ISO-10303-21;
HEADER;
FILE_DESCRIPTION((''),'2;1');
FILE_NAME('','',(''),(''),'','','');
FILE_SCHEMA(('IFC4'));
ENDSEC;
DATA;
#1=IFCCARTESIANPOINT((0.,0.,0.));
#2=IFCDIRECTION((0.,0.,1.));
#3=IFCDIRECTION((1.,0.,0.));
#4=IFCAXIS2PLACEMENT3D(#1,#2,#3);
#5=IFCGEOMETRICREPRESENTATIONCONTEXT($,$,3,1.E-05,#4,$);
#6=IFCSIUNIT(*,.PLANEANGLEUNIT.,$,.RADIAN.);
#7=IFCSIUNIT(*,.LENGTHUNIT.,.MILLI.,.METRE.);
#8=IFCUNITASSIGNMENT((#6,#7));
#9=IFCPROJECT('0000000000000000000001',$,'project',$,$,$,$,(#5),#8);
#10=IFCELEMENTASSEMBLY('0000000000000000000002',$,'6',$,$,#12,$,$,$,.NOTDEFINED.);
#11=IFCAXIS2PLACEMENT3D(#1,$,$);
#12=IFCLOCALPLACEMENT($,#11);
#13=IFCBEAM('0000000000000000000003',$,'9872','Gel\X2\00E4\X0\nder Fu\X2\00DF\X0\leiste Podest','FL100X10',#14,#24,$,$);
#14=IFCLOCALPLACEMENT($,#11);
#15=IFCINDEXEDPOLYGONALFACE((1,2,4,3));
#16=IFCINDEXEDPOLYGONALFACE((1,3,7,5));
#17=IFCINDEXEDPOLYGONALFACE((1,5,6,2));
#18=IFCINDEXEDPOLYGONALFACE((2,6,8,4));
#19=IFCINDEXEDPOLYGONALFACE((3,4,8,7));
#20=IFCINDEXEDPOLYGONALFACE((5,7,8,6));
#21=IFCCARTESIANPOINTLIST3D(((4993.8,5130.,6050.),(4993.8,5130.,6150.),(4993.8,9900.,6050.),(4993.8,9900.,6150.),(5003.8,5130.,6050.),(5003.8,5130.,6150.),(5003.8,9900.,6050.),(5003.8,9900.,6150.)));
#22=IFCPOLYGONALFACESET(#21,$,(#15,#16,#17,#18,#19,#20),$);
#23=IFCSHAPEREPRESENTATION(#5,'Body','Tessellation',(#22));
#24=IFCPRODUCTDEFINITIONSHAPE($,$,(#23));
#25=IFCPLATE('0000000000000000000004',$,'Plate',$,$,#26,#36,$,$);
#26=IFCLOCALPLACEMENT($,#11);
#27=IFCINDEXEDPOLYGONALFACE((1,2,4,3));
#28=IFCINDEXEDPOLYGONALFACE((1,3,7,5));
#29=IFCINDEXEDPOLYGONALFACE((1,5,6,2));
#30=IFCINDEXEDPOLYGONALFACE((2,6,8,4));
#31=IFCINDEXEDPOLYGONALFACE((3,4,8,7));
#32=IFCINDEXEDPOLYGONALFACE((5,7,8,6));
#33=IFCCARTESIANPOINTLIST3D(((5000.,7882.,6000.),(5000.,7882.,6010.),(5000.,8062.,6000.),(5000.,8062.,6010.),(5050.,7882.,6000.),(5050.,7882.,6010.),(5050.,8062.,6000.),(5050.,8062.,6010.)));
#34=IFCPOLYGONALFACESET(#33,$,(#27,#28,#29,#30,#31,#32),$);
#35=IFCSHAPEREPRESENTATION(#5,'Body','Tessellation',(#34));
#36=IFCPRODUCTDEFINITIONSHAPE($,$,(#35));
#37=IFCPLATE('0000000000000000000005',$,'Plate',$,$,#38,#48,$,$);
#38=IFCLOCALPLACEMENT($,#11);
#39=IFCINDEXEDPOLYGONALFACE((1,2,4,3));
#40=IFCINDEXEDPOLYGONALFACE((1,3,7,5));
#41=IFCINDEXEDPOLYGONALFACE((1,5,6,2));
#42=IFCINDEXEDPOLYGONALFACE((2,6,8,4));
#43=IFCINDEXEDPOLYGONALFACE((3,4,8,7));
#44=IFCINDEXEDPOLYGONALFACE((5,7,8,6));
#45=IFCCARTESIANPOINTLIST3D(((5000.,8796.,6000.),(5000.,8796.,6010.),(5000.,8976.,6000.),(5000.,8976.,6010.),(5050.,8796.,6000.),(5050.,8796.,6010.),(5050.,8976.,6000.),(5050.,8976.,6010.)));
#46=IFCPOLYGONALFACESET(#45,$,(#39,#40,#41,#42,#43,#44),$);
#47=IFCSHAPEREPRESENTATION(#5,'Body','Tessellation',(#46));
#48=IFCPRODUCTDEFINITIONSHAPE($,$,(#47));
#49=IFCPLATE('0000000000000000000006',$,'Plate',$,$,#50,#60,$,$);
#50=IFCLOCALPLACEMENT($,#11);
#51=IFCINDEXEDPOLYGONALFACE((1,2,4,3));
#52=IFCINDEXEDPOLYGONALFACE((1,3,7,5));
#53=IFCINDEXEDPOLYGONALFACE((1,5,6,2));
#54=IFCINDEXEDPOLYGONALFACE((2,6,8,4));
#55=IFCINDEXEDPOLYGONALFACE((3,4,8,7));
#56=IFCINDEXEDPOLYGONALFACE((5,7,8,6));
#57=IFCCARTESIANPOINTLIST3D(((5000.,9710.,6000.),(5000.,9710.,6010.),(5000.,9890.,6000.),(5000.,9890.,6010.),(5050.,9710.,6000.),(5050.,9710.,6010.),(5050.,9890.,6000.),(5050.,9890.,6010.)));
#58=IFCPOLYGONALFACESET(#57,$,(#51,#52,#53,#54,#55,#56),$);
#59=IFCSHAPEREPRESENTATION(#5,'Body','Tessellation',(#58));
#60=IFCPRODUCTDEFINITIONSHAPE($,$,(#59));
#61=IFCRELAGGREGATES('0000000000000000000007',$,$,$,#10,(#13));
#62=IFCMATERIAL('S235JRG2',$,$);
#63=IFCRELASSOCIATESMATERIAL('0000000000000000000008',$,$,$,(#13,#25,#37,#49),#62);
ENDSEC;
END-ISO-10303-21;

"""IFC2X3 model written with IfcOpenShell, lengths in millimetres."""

from ifc_helpers import new_model, si_unit, frame, origin_with_axes, place, context, project, polyline, outline, extrude, material, element, aggregate, save


model = new_model("IFC2X3")

# Units and contexts
context_of_model = context(None, 3, precision=1e-05, world=origin_with_axes())
ifc_project = project(units=[si_unit("PLANEANGLEUNIT", "RADIAN"), si_unit("LENGTHUNIT", "METRE", prefix="MILLI")], contexts=[context_of_model])

# Element assembly, beam
assembly_placement = place(None, frame((1.2, 5130.0, 6100.0), z_axis=(0.0, 0.0, 1.0), x_axis=(0.0, 1.0, 0.0)))
assembly = element("IfcElementAssembly", 1, at=assembly_placement, Name="6", PredefinedType="NOTDEFINED")
ifc_material = material(Name="S235JRG2")
placement_1 = place(None, frame((4998.8, 9900.0, 6100.0), z_axis=(0.0, 0.0, 1.0), x_axis=(0.0, -1.0, 0.0)))
beam_1_placement = place(placement_1, origin_with_axes())
beam_1 = element("IfcBeam", 2, at=beam_1_placement, material=ifc_material, Name="9872", Description="Geländer Fußleiste Podest", ObjectType="FL100X10", context=context_of_model, shape_type="SweptSolid", body=[
    extrude(outline(polyline([(5.0, -50.0), (5.0, 50.0), (-5.0, 50.0), (-5.0, -50.0), (5.0, -50.0), (5.0, -50.0)])), frame((0.0, 0.0, 0.0), z_axis=(1.0, 0.0, 0.0), x_axis=(0.0, 1.0, 0.0)), (0.0, 0.0, 1.0), 4770.0),
])
aggregate(assembly, [beam_1])

# Plates
placement_2 = place(None, origin_with_axes())
plate_1_placement = place(placement_2, frame((5000.0, 7882.0, 6010.0), z_axis=(1.0, 0.0, 0.0), x_axis=(0.0, 0.0, -1.0)))
element("IfcPlate", 3, at=plate_1_placement, material=ifc_material, Name="Plate", context=context_of_model, shape_type="SweptSolid", body=[
    extrude(outline(polyline([(0.0, 0.0), (180.0, 0.0), (180.0, 50.0), (0.0, 50.0), (0.0, 0.0)])), frame((0.0, 0.0, 0.0), z_axis=(1.0, 0.0, 0.0), x_axis=(0.0, 1.0, 0.0)), (0.0, 0.0, 1.0), 10.0),
])
placement_3 = place(None, origin_with_axes())
plate_2_placement = place(placement_3, frame((5000.0, 8796.0, 6010.0), z_axis=(1.0, 0.0, 0.0), x_axis=(0.0, 0.0, -1.0)))
element("IfcPlate", 4, at=plate_2_placement, material=ifc_material, Name="Plate", context=context_of_model, shape_type="SweptSolid", body=[
    extrude(outline(polyline([(0.0, 0.0), (180.0, 0.0), (180.0, 50.0), (0.0, 50.0), (0.0, 0.0)])), frame((0.0, 0.0, 0.0), z_axis=(1.0, 0.0, 0.0), x_axis=(0.0, 1.0, 0.0)), (0.0, 0.0, 1.0), 10.0),
])
placement_4 = place(None, origin_with_axes())
plate_3_placement = place(placement_4, frame((5000.0, 9710.0, 6010.0), z_axis=(1.0, 0.0, 0.0), x_axis=(0.0, 0.0, -1.0)))
element("IfcPlate", 5, at=plate_3_placement, material=ifc_material, Name="Plate", context=context_of_model, shape_type="SweptSolid", body=[
    extrude(outline(polyline([(0.0, 0.0), (180.0, 0.0), (180.0, 50.0), (0.0, 50.0), (0.0, 0.0)])), frame((0.0, 0.0, 0.0), z_axis=(1.0, 0.0, 0.0), x_axis=(0.0, 1.0, 0.0)), (0.0, 0.0, 1.0), 10.0),
])

save(model, "model.ifc")
